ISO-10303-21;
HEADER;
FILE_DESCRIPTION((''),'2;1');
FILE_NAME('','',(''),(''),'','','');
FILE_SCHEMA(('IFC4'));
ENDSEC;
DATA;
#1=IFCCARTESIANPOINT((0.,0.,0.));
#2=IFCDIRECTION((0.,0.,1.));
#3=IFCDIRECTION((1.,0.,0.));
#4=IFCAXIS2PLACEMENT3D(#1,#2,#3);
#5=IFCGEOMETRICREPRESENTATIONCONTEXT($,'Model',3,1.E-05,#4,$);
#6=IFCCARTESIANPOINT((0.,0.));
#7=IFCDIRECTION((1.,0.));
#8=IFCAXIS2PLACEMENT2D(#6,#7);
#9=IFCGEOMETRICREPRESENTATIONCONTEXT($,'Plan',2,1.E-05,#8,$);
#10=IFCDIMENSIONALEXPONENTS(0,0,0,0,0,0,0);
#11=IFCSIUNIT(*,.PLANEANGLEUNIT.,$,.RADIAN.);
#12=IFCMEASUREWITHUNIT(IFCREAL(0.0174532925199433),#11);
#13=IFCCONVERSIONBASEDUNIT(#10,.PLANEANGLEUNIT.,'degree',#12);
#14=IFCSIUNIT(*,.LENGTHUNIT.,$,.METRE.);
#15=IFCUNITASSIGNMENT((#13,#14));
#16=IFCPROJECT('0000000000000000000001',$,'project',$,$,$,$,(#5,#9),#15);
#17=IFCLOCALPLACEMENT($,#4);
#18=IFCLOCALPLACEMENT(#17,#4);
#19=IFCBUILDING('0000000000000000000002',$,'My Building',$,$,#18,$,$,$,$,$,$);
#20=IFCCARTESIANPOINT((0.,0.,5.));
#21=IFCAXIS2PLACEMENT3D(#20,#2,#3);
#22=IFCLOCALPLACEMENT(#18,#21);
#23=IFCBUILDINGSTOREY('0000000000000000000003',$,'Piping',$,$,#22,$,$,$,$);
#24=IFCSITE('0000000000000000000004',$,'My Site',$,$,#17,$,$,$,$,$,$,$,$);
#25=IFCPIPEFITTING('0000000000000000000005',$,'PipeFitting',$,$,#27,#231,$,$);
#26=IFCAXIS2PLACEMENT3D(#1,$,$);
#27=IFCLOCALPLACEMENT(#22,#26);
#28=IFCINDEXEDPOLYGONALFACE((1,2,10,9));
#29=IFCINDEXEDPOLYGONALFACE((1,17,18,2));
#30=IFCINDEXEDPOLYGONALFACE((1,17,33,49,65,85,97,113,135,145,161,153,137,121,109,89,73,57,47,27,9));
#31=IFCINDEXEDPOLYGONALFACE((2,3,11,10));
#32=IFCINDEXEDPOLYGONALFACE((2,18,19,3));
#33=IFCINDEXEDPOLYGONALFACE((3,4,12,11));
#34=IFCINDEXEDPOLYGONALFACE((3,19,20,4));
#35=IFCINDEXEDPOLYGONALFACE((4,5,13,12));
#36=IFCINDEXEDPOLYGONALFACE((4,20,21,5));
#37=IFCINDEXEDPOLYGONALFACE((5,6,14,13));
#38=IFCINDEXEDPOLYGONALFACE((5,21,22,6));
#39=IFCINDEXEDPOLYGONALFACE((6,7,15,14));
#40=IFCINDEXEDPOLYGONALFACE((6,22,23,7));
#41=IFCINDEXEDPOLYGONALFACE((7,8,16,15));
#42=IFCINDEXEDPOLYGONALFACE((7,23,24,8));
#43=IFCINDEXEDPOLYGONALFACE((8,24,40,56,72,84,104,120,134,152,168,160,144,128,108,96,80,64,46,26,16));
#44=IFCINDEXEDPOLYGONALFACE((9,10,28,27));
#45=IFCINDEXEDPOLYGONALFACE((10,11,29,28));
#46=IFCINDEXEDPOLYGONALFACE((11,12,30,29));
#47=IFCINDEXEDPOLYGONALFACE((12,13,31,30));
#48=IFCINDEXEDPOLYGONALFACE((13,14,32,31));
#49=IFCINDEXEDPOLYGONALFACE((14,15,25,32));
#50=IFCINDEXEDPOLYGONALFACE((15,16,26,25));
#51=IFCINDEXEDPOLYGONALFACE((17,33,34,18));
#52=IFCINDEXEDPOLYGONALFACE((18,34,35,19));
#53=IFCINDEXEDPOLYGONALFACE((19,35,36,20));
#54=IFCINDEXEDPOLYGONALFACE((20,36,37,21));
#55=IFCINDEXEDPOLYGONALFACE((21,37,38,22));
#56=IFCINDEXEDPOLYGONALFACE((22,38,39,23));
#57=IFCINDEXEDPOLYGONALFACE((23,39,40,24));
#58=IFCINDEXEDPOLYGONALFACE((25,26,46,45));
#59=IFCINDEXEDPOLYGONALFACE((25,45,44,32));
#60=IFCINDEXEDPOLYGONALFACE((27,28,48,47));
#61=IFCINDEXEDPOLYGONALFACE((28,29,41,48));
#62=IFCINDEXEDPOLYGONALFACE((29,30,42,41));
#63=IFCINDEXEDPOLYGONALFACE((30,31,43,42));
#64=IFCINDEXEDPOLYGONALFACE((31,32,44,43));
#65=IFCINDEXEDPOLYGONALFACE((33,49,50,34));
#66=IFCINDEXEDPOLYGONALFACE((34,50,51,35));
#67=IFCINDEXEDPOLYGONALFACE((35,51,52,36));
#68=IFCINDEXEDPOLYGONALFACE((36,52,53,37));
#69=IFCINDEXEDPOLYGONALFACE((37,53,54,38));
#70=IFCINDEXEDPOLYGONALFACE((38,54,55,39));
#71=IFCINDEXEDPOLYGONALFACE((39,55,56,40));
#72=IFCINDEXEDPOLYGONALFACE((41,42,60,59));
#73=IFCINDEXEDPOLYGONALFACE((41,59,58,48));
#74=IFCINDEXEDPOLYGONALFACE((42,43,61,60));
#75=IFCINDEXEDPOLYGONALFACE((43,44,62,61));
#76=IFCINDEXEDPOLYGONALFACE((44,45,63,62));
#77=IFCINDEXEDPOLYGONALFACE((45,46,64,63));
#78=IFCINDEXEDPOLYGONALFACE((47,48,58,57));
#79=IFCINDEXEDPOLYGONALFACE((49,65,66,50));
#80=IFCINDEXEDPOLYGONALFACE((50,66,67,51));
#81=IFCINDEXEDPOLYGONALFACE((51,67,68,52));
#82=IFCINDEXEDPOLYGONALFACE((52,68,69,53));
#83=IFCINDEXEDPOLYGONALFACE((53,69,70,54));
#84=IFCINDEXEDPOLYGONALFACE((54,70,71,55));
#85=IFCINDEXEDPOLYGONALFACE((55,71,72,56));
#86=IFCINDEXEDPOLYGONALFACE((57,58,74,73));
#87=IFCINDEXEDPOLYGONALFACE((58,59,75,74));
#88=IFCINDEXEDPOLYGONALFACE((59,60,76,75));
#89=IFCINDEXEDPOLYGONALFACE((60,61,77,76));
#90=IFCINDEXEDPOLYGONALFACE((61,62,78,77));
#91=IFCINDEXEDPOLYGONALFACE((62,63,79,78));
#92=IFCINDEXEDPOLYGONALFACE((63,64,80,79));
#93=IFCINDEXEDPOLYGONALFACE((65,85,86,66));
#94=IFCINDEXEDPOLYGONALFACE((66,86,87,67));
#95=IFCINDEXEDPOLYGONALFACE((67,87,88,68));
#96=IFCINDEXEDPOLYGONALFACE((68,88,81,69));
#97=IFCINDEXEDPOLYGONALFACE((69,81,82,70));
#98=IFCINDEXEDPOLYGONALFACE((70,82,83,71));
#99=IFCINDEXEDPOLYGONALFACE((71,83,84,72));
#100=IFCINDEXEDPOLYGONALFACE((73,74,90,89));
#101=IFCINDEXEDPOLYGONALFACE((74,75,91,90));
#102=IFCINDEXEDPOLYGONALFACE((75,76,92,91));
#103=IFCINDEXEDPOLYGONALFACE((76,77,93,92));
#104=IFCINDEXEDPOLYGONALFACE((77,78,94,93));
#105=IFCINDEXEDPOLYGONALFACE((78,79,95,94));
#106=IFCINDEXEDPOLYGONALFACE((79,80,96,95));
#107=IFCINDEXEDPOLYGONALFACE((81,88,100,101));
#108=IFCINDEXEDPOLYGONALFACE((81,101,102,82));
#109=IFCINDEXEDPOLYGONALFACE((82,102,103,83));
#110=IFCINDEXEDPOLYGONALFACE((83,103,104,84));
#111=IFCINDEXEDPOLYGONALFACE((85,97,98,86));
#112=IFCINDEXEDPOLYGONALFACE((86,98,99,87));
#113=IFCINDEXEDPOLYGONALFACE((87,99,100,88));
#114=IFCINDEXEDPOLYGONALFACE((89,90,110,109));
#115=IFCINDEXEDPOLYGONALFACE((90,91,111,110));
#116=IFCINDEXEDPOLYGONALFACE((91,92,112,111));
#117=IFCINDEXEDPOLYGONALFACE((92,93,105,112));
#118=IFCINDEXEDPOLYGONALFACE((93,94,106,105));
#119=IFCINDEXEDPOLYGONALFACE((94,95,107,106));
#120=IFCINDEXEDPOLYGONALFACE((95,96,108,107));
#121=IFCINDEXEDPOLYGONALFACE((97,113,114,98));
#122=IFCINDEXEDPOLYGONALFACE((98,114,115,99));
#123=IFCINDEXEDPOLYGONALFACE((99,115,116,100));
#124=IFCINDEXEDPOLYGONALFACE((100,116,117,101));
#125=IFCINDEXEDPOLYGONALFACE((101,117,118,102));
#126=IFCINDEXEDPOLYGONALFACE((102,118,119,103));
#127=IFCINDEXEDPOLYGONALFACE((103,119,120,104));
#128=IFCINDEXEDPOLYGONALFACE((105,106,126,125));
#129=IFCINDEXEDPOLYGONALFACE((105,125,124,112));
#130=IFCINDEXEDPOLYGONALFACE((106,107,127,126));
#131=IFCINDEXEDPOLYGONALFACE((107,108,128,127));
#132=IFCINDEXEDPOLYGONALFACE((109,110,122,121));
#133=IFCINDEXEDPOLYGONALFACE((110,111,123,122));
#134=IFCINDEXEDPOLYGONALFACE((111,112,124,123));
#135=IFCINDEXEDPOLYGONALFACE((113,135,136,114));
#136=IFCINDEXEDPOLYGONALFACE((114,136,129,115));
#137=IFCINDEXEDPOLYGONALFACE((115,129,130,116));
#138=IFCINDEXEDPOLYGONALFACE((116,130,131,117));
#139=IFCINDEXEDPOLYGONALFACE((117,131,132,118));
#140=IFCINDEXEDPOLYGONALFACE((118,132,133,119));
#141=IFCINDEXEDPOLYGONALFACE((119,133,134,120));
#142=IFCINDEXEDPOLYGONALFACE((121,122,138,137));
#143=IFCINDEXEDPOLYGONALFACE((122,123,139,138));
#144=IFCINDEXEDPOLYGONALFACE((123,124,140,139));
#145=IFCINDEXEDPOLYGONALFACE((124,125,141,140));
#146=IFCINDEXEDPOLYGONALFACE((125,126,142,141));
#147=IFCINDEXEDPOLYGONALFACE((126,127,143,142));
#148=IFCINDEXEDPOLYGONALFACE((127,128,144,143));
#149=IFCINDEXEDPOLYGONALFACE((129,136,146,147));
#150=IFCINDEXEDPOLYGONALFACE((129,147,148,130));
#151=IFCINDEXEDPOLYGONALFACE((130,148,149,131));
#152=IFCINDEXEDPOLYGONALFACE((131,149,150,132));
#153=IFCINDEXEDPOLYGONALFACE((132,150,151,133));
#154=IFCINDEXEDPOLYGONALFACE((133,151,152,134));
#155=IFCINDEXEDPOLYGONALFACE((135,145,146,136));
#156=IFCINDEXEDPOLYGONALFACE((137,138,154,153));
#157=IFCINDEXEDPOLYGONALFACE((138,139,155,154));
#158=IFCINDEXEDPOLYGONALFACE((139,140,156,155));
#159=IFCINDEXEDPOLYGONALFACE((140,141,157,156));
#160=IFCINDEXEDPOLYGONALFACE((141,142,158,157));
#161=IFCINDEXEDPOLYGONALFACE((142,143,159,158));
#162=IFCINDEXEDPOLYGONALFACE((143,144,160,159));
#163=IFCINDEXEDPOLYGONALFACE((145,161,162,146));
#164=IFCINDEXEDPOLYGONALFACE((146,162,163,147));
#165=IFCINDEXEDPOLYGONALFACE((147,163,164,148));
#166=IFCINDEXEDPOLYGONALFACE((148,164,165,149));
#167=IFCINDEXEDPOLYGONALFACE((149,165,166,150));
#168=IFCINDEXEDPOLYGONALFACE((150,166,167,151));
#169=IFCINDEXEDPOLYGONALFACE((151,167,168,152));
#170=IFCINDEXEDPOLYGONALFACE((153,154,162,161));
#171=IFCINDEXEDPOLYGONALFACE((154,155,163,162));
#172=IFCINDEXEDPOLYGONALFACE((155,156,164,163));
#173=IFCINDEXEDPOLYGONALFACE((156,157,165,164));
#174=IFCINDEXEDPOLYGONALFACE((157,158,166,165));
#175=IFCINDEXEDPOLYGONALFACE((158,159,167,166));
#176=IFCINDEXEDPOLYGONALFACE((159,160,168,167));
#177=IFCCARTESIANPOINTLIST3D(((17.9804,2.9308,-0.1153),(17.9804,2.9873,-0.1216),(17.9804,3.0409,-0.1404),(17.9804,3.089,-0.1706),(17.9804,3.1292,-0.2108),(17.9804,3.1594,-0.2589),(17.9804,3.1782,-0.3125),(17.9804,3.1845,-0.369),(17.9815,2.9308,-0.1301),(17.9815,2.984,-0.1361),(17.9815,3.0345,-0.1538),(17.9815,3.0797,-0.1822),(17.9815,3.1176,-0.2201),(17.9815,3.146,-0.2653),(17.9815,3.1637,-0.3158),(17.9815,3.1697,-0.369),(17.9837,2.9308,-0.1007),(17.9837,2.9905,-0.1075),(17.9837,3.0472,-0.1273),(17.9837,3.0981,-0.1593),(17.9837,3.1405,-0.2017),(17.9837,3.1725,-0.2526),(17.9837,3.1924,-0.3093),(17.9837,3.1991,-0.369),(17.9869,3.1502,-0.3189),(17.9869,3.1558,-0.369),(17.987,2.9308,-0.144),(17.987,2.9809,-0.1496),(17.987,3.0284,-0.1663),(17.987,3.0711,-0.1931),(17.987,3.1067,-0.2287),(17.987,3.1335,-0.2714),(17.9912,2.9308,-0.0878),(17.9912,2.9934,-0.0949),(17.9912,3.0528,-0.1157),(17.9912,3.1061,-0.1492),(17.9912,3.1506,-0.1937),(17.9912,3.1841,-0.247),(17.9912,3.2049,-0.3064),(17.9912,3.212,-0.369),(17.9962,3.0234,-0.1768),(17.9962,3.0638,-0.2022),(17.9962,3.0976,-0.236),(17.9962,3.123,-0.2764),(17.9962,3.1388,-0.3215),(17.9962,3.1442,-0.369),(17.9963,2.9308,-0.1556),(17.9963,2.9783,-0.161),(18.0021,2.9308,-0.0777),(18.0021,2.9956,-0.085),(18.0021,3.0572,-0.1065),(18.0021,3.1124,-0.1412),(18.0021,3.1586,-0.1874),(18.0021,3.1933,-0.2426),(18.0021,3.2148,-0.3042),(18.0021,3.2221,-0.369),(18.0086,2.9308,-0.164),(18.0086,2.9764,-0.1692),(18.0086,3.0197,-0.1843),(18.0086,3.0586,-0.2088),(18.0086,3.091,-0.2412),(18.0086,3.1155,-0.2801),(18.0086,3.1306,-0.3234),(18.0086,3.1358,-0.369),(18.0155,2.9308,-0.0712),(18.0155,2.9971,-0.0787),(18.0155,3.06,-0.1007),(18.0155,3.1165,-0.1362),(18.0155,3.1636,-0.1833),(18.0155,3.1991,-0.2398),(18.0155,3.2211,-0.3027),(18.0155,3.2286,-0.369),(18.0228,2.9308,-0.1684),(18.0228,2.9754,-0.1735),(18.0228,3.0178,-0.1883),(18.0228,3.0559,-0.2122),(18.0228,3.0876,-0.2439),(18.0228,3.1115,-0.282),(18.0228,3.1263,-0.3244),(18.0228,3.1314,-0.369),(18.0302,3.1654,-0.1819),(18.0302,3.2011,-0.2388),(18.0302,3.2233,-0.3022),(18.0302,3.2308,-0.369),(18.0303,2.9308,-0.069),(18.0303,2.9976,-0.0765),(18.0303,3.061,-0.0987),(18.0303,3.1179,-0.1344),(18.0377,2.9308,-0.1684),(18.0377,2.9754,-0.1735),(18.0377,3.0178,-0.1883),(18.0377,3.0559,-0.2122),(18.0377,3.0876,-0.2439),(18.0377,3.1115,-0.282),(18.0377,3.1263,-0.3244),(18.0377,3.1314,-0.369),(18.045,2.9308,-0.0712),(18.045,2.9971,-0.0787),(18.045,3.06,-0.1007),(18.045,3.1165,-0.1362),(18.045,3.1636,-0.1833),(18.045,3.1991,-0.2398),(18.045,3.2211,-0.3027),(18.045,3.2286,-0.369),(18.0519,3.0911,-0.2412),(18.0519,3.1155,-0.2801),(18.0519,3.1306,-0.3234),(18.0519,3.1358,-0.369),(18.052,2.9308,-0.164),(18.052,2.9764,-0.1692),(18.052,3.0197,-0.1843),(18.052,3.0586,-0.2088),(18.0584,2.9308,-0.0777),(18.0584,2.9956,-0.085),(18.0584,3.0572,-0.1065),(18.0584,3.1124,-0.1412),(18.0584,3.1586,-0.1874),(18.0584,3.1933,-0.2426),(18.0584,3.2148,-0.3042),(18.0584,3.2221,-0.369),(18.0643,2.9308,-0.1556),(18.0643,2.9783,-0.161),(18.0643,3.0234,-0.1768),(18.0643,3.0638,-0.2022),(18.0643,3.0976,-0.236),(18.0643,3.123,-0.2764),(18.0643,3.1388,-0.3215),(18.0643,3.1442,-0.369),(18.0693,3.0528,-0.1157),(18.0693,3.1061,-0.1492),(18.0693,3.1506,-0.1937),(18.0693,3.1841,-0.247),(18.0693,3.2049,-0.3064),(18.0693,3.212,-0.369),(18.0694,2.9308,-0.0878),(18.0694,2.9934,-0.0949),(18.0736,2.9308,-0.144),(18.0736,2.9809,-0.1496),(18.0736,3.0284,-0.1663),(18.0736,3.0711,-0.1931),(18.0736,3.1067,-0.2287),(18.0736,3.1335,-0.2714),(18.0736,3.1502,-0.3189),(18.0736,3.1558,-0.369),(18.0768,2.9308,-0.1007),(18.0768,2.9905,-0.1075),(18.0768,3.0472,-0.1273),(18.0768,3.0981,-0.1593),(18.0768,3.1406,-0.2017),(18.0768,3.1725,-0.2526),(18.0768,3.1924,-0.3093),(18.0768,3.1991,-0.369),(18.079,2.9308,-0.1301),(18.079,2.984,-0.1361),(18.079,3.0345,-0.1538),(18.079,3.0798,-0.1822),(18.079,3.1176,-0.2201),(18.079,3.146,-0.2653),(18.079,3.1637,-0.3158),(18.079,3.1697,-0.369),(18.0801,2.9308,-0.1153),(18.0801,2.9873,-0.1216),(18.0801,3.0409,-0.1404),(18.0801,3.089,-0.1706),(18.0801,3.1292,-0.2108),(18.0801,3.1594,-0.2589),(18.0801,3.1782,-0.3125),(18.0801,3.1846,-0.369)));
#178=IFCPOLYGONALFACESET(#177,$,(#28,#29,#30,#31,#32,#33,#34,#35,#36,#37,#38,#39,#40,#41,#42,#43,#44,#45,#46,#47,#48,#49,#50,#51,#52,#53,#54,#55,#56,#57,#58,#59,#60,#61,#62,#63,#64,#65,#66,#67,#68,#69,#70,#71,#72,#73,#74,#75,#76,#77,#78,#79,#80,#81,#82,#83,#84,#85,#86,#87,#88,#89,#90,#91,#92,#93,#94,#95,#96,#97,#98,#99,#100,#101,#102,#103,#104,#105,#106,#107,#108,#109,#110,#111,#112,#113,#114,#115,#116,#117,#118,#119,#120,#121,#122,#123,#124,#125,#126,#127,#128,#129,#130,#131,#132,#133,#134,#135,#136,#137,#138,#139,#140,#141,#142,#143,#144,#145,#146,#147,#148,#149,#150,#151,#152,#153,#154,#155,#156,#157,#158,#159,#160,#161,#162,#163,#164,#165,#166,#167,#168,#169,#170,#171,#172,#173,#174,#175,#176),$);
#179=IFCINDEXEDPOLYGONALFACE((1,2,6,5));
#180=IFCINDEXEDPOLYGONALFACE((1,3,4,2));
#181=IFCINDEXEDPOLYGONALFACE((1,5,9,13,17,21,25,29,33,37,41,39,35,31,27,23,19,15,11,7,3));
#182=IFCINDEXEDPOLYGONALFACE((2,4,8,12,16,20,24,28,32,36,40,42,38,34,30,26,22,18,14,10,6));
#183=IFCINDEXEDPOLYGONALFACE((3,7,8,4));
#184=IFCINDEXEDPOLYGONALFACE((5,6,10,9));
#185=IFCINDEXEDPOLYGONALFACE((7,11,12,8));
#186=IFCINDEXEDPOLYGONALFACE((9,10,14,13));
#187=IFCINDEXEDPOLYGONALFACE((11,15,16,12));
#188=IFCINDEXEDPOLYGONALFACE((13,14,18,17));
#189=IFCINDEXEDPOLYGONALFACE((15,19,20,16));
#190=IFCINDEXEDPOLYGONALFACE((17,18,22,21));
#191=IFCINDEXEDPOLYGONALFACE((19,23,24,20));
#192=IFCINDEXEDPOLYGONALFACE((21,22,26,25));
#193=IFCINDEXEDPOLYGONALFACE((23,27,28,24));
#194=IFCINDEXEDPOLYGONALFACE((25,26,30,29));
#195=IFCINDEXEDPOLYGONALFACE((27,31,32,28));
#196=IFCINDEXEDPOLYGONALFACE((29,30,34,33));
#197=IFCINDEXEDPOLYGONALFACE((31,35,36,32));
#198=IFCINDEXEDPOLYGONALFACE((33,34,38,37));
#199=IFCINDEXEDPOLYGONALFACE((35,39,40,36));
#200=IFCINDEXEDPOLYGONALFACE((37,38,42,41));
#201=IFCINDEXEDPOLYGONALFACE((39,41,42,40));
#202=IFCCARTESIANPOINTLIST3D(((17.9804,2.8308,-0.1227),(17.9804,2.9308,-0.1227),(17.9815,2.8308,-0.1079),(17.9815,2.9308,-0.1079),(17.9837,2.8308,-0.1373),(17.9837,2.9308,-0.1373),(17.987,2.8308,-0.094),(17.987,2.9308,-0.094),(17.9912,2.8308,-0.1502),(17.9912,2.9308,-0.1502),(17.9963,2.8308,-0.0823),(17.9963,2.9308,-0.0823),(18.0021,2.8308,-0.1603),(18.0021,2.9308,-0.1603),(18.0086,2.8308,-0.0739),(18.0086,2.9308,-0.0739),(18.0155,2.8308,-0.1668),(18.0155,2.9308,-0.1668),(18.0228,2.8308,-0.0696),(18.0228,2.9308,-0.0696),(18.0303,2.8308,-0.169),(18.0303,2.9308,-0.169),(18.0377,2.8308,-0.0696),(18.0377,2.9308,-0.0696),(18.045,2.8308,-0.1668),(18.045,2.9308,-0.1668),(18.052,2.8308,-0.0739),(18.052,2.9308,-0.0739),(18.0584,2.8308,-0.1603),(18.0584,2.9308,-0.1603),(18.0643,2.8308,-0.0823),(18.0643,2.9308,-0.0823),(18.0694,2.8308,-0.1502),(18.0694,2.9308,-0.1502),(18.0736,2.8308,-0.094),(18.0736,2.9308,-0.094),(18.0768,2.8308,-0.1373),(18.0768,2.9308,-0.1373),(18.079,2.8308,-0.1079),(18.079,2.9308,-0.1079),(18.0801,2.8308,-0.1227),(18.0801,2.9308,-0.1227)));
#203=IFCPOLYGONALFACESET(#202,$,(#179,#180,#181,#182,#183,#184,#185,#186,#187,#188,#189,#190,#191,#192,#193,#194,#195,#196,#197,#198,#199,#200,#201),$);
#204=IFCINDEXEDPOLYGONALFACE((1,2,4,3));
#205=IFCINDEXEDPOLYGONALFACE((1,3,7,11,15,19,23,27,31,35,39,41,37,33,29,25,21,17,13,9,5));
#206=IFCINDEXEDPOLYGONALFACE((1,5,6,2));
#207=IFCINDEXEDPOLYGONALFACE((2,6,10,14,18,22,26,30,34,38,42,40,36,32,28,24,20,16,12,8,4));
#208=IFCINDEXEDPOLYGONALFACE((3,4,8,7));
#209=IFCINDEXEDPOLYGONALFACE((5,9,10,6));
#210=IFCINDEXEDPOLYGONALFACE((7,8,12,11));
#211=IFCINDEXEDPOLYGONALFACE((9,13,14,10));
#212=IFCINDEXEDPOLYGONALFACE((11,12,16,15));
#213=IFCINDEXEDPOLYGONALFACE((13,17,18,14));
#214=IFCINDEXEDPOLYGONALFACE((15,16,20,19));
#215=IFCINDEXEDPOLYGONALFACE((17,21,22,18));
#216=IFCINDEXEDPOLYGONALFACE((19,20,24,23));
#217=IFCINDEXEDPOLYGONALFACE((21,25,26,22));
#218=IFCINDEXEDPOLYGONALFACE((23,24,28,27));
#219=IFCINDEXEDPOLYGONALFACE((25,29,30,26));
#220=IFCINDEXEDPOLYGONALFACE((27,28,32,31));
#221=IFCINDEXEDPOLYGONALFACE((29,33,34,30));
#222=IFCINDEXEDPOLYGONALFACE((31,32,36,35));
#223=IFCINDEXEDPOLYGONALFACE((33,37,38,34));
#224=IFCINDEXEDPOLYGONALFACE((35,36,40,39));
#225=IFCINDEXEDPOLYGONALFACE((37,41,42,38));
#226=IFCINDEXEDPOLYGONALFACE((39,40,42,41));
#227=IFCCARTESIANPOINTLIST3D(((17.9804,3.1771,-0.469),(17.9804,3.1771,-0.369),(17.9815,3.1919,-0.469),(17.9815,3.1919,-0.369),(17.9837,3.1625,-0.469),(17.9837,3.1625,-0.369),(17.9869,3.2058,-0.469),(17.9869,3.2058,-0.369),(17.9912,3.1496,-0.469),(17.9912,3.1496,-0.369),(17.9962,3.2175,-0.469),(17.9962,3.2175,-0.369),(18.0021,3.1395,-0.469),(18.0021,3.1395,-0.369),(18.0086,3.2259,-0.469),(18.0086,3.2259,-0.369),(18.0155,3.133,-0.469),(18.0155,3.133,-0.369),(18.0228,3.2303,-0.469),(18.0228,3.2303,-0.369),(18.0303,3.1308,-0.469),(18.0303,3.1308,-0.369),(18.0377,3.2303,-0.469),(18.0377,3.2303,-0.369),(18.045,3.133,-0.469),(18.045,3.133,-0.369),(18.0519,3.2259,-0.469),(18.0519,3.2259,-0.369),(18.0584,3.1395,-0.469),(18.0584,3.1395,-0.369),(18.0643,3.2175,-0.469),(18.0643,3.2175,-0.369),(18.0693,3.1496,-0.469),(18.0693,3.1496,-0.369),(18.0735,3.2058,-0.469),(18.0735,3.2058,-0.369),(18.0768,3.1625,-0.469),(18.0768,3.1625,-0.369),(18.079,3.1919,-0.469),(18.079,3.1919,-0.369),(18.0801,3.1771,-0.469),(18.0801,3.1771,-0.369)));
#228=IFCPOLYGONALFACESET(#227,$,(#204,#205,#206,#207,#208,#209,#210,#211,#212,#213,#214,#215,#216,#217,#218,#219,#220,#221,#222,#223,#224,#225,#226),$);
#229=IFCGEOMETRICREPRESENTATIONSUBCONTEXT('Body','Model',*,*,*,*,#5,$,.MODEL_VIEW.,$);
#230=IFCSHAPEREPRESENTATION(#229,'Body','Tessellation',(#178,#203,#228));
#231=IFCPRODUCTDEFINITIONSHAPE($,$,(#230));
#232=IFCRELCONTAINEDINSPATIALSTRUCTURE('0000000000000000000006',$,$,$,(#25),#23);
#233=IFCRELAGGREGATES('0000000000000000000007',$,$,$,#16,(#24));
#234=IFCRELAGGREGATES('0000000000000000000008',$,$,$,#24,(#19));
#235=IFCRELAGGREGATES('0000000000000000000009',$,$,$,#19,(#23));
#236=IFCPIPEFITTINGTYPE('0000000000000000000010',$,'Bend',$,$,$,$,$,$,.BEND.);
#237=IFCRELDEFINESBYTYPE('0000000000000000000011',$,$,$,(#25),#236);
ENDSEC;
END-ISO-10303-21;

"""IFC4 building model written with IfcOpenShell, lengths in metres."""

from ifc_helpers import new_model, entity, si_unit, converted_unit, frame, origin_with_axes, origin_2d_with_axis, place, context, subcontext, project, spatial, circle, extrude, source, transform, mapped, type_object, type_shapes, element, save


model = new_model("IFC4")

# Units and contexts
model_context = context("Model", 3, precision=1e-05, world=origin_with_axes())
plan_context = context("Plan", 2, precision=1e-05, world=origin_2d_with_axis())
body_context = subcontext(model_context, "Body", "Model", "MODEL_VIEW")
ifc_project = project(units=[converted_unit("PLANEANGLEUNIT", "degree", entity("IfcReal", 0.0174532925199433), si_unit("PLANEANGLEUNIT", "RADIAN"), dimensions=[0, 0, 0, 0, 0, 0, 0]), si_unit("LENGTHUNIT", "METRE")], contexts=[model_context, plan_context])

# Site, building, storey
site_placement = place(None, origin_with_axes())
site = spatial("IfcSite", under=ifc_project, at=site_placement, Name="My Site")
building_placement = place(site_placement, origin_with_axes())
building = spatial("IfcBuilding", under=site, at=building_placement, Name="My Building")
storey_placement = place(building_placement, frame((0.0, 0.0, 5.0), z_axis=(0.0, 0.0, 1.0), x_axis=(1.0, 0.0, 0.0)))
storey = spatial("IfcBuildingStorey", under=building, at=storey_placement, Name="Piping")

# Pipe fitting
pipe_fitting_type_1 = type_object("IfcPipeFittingType", Name="Bend", PredefinedType="BEND")
shared_shape = source(origin_with_axes(), body_context, "Body", "SolidModel", [
    entity("IfcSweptDiskSolid", entity("IfcIndexedPolyCurve", entity("IfcCartesianPointList3D", [[0.0, 0.0, -0.1], [0.0732, 0.0, -0.2768], [0.25, 0.0, -0.35]]), [entity("IfcArcIndex", [1, 2, 3])]), 0.05),
    extrude(circle(Radius=0.05), origin_with_axes(), (0.0, 0.0, -1.0), 0.1),
    extrude(circle(Radius=0.05), frame((0.25, 0.0, -0.35), z_axis=(1.0, 0.0, 0.0), x_axis=(0.0, 0.0, 1.0)), (0.0, 0.0, 1.0), 0.1),
])
type_shapes(pipe_fitting_type_1, [shared_shape])
for number, where, z_axis, x_axis, name in (
    (1, (18.0303, 2.8308, -0.119), (0.00006, -1.0, 0.0), (0.0, 0.0, -1.0), "PipeFitting"),
):
    element("IfcPipeFitting", number, at=place(storey_placement, frame(where, z_axis=z_axis, x_axis=x_axis)), inside=storey, type_object=pipe_fitting_type_1, Name=name, context=body_context, shape_type="MappedRepresentation", body=[
        mapped(shared_shape, transform((0.0, 0.0, 0.0), x_axis=(1.0, 0.0, 0.0), y_axis=(0.0, 1.0, 0.0), z_axis=(0.0, 0.0, 1.0), scale=1.0)),
    ])

save(model, "model.ifc")
